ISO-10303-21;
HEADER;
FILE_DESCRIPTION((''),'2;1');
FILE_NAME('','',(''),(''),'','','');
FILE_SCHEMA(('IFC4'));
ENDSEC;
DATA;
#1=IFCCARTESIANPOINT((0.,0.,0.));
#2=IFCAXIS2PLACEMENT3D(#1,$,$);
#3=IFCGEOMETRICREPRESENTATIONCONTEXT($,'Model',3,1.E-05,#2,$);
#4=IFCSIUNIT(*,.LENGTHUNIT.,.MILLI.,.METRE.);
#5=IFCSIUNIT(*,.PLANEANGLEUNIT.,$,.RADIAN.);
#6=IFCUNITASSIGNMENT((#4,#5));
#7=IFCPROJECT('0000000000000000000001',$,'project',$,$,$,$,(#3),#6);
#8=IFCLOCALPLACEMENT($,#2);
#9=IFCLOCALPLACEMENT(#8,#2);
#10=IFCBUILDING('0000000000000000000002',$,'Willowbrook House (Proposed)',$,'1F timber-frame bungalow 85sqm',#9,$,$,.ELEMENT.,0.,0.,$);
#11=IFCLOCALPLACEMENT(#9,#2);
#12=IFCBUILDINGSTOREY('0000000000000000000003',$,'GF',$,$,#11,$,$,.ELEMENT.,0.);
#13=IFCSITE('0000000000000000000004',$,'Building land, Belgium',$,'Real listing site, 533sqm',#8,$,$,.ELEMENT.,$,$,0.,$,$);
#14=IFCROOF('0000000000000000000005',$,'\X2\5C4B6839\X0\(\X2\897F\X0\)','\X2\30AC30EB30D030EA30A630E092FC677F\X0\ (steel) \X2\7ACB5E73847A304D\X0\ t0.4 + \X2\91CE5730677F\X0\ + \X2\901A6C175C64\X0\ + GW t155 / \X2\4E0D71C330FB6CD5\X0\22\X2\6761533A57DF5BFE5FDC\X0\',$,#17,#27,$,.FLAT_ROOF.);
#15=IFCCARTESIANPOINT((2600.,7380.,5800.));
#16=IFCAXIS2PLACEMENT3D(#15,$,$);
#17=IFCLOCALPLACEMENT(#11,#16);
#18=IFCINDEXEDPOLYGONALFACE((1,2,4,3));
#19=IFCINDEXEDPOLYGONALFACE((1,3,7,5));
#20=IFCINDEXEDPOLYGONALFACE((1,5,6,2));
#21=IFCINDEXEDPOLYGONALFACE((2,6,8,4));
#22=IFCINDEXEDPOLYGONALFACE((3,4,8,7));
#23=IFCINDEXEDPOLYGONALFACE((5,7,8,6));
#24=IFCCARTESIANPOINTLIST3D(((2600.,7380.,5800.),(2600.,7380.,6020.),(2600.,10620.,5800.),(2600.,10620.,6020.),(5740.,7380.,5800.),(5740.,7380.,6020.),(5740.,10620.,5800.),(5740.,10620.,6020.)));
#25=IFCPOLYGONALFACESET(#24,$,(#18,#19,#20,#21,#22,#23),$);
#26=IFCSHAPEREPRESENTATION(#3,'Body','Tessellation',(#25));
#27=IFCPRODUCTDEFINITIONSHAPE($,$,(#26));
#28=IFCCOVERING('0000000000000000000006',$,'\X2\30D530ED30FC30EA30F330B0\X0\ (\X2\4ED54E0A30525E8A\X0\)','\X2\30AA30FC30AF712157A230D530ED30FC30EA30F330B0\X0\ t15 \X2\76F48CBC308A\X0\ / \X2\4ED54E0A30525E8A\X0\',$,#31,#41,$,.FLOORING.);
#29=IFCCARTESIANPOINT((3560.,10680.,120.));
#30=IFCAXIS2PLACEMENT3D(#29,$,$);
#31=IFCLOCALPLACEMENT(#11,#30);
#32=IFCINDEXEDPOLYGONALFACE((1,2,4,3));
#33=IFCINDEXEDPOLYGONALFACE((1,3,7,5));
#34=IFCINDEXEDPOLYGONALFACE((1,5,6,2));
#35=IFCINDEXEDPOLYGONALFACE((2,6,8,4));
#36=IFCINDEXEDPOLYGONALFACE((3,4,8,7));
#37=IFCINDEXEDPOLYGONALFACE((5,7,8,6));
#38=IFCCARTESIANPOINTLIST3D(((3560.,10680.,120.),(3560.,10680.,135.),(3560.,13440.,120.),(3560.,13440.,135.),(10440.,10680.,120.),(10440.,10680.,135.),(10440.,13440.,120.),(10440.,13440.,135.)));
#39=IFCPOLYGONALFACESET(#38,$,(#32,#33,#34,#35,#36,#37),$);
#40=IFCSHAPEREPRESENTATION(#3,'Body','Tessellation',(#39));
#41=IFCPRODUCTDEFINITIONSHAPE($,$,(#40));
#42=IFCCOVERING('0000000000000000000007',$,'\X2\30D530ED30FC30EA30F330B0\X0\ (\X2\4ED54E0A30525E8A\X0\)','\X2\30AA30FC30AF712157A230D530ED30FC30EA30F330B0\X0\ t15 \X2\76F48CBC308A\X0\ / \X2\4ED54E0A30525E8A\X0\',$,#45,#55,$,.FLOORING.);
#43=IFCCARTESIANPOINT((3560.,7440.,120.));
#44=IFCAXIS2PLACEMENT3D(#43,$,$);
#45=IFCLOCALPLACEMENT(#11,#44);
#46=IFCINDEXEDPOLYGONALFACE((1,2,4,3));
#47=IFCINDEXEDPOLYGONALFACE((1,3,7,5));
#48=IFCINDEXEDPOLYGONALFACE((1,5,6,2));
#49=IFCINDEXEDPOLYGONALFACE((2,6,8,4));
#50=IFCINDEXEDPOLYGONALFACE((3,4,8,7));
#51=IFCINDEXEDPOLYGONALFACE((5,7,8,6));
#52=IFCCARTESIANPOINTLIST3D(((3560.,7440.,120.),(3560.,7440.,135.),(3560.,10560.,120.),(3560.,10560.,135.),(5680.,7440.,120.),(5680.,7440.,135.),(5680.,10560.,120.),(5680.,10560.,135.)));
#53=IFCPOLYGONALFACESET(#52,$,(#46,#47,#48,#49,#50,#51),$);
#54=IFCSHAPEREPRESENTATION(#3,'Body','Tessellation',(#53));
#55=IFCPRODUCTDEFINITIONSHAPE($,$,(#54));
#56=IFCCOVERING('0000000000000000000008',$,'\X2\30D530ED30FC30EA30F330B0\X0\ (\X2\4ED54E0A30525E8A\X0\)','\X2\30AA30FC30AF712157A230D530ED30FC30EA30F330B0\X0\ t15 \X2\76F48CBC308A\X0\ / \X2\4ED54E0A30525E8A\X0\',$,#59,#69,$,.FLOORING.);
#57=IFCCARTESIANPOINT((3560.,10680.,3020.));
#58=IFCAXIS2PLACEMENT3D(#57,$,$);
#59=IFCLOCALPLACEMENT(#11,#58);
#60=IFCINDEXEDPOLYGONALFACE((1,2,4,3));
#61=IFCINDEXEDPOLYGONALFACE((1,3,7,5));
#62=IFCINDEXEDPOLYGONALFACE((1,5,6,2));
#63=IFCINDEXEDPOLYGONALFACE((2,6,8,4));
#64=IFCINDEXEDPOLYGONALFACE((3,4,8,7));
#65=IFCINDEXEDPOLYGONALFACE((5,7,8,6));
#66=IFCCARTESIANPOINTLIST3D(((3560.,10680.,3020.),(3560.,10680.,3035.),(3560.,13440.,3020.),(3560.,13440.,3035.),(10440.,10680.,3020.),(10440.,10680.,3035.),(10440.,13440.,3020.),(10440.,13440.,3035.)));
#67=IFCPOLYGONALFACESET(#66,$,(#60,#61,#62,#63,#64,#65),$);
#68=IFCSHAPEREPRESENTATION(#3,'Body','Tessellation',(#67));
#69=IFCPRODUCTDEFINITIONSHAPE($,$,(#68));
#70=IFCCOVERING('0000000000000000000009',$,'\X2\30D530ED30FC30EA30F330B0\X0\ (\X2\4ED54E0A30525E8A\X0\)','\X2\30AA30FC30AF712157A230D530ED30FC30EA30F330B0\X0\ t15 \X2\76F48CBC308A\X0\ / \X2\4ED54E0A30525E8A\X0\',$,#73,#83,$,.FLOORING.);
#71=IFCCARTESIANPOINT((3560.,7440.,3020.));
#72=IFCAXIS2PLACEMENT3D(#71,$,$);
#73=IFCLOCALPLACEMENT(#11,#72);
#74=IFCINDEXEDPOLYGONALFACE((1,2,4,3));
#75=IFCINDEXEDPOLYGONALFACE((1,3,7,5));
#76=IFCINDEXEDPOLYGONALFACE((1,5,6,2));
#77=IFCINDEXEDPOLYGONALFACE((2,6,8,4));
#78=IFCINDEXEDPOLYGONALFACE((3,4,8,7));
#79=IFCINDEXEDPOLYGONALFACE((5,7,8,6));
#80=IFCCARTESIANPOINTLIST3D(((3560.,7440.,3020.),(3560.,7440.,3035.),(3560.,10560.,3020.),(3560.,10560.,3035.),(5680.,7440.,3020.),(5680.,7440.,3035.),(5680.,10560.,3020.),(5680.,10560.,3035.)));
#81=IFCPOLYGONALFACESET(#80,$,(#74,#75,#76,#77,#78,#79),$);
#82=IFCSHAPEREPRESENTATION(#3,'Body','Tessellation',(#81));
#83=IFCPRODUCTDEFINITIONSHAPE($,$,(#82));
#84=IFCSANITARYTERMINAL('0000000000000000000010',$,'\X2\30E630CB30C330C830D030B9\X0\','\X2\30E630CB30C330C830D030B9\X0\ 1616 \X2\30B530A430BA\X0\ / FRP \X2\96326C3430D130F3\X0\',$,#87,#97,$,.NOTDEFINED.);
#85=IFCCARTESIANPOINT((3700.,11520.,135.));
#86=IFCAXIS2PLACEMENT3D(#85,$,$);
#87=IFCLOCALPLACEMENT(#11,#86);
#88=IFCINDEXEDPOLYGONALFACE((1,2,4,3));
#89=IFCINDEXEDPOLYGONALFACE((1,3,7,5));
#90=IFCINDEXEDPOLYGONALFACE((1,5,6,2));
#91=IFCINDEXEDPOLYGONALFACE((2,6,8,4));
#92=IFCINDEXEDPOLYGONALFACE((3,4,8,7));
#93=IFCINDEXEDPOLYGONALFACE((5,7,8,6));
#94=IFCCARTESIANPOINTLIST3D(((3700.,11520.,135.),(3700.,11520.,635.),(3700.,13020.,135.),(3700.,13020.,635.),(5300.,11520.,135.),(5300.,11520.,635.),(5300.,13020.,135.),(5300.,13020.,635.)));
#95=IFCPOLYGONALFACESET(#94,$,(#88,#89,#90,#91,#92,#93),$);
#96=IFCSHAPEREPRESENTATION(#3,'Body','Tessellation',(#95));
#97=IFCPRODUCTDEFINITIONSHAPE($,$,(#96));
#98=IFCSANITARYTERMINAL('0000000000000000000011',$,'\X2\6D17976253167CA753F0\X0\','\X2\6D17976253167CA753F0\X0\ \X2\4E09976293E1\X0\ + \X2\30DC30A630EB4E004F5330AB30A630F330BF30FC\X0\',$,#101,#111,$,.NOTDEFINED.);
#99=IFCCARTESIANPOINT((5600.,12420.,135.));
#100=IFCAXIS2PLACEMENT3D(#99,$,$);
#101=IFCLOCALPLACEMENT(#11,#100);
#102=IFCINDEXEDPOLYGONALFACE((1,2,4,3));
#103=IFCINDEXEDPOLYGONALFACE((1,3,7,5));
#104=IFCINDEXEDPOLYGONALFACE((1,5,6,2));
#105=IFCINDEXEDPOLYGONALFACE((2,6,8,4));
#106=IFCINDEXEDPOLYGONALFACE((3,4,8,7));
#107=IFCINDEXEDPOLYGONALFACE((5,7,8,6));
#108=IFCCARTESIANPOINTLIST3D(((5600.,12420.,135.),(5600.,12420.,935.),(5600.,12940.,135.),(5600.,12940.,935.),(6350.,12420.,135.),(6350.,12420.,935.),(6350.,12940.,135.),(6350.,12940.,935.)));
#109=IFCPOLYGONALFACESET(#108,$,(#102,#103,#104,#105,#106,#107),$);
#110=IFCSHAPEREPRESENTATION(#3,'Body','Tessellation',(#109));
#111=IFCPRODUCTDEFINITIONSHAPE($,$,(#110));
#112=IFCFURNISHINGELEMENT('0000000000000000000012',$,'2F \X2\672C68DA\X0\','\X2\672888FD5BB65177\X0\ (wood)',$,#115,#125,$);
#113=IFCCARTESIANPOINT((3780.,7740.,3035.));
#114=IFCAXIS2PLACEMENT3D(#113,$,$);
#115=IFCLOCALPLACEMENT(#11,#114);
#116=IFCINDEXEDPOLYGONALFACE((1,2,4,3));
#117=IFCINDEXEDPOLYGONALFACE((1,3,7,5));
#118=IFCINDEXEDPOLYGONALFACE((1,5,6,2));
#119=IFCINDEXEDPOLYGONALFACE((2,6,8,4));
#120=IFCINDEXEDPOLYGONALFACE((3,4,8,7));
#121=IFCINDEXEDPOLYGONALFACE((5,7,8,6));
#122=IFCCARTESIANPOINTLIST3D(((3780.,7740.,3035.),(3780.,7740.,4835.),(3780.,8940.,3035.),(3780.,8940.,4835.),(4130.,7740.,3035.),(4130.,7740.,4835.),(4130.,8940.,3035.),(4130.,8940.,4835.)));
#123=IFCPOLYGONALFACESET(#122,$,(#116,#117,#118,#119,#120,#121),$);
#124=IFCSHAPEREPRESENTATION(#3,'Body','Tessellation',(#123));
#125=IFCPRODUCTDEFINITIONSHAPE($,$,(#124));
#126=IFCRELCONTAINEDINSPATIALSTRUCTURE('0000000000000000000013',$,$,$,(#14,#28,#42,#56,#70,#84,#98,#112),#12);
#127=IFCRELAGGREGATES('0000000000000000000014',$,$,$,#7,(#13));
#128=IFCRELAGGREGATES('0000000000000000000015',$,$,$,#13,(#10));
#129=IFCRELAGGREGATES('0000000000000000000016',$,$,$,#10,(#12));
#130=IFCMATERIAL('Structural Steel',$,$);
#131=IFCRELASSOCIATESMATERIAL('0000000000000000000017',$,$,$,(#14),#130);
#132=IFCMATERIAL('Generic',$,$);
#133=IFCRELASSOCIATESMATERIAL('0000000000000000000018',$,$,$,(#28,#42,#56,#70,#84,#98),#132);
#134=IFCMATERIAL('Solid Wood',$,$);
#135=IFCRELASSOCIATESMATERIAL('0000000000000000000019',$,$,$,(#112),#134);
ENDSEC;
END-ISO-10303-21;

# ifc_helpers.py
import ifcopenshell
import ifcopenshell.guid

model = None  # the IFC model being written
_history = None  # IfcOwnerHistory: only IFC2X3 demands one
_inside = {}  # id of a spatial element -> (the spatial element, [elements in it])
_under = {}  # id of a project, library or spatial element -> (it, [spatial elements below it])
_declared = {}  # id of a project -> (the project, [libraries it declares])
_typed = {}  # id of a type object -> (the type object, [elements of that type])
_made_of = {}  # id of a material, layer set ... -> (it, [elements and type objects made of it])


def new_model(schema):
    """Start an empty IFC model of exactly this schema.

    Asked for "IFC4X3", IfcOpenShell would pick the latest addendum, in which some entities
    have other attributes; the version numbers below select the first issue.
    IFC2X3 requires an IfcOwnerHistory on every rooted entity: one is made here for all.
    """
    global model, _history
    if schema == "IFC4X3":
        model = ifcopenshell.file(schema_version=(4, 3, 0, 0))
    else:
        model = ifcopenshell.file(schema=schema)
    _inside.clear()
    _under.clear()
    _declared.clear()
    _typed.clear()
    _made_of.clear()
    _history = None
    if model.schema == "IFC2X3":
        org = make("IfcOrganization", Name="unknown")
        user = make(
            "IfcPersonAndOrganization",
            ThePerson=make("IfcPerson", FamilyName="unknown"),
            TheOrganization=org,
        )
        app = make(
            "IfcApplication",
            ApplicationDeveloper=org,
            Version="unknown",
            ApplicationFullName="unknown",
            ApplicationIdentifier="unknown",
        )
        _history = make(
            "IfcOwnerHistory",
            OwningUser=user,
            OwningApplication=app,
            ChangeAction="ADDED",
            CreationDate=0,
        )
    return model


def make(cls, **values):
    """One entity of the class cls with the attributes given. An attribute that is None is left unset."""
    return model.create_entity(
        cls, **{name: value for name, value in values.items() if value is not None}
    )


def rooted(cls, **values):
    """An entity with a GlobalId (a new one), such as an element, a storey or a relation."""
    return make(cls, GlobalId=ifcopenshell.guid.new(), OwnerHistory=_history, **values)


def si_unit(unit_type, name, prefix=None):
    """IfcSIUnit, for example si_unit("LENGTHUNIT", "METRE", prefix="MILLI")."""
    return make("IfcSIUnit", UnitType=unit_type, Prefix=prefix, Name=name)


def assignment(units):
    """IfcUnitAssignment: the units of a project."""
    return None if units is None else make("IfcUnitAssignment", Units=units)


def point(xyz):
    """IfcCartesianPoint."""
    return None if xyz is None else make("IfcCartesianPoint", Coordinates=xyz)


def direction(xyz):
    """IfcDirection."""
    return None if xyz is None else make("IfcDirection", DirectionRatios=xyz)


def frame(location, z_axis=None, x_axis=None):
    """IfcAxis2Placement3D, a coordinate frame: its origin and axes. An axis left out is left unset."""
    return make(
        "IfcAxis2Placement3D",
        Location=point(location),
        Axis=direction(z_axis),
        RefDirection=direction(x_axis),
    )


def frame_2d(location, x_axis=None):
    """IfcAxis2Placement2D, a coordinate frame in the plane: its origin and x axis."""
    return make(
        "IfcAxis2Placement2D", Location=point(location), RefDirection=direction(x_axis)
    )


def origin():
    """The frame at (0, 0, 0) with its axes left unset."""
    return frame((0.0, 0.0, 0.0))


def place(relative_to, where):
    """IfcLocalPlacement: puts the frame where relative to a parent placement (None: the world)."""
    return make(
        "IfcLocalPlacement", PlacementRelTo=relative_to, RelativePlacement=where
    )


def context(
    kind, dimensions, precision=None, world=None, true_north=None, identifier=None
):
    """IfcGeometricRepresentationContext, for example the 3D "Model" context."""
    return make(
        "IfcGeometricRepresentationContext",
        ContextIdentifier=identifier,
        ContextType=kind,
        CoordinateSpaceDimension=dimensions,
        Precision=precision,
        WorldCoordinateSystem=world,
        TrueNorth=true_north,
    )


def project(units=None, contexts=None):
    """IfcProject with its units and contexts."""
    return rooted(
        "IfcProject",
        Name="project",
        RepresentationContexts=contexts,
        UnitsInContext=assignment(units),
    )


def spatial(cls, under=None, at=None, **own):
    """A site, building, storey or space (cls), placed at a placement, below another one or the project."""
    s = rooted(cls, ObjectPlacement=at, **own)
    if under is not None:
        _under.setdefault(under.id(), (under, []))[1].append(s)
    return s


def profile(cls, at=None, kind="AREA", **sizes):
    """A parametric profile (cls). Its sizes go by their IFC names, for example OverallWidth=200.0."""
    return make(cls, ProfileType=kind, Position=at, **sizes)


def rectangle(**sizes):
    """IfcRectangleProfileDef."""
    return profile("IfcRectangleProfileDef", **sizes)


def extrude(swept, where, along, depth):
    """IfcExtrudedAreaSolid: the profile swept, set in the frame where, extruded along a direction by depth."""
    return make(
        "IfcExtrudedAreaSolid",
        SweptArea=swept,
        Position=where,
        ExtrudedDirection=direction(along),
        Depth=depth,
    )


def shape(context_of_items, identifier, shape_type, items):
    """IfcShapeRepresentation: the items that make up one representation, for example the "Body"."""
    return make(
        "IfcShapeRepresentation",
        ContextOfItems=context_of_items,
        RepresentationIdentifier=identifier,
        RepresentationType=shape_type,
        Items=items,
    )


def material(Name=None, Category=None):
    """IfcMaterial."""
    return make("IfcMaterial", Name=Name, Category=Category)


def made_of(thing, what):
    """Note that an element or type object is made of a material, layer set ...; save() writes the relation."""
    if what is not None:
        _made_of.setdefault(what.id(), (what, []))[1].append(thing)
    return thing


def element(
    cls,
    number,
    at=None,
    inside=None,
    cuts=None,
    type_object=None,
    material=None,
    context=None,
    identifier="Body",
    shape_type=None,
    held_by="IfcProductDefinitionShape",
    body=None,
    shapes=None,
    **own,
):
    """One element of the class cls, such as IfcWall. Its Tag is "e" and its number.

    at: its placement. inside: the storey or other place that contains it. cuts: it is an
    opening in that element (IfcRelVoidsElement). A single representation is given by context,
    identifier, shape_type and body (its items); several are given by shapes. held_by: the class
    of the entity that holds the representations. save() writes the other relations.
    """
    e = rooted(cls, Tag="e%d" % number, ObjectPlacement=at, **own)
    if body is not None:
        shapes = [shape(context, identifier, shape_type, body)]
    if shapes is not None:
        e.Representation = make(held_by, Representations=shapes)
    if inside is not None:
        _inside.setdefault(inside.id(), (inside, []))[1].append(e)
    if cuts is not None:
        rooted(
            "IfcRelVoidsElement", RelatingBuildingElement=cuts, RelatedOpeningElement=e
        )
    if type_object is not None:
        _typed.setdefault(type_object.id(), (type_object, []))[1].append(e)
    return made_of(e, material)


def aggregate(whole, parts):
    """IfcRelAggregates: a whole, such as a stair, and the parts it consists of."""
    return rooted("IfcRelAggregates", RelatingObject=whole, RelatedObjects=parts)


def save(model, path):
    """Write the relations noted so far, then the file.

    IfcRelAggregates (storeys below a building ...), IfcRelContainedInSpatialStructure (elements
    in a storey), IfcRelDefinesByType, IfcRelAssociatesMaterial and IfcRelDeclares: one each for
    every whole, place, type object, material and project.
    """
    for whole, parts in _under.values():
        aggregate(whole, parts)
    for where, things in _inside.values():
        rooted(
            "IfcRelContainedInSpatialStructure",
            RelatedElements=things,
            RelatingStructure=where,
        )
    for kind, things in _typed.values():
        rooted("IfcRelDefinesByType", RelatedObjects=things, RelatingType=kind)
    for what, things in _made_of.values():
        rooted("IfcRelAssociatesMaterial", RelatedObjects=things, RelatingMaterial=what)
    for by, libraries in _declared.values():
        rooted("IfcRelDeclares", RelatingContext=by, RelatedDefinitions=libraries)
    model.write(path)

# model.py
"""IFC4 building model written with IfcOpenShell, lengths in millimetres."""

from ifc_helpers import new_model, si_unit, frame, frame_2d, origin, place, context, project, spatial, rectangle, extrude, material, element, save


model = new_model("IFC4")

# Units and contexts
model_context = context("Model", 3, precision=1e-05, world=origin())
ifc_project = project(units=[si_unit("LENGTHUNIT", "METRE", prefix="MILLI"), si_unit("PLANEANGLEUNIT", "RADIAN")], contexts=[model_context])

# Site, building, storey
site_placement = place(None, origin())
site = spatial("IfcSite", under=ifc_project, at=site_placement, Name="Building land, Belgium", ObjectType="Real listing site, 533sqm", CompositionType="ELEMENT", RefElevation=0.0)
building_placement = place(site_placement, origin())
building = spatial("IfcBuilding", under=site, at=building_placement, Name="Willowbrook House (Proposed)", ObjectType="1F timber-frame bungalow 85sqm", CompositionType="ELEMENT", ElevationOfRefHeight=0.0, ElevationOfTerrain=0.0)
storey_placement = place(building_placement, origin())
storey = spatial("IfcBuildingStorey", under=building, at=storey_placement, Name="GF", CompositionType="ELEMENT", Elevation=0.0)

# Shared definitions
ifc_material_1 = material(Name="Solid Wood")

# Roof
ifc_material_2 = material(Name="Structural Steel")
roof_placement = place(storey_placement, frame((2600.0, 7380.0, 5800.0)))
element("IfcRoof", 1, at=roof_placement, inside=storey, material=ifc_material_2, Name="屋根(西)", Description="ガルバリウム鋼板 (steel) 立平葺き t0.4 + 野地板 + 通気層 + GW t155 / 不燃・法22条区域対応", PredefinedType="FLAT_ROOF", context=model_context, shape_type="SweptSolid", body=[
    extrude(rectangle(XDim=3140.0, YDim=3240.0, at=frame_2d((1570.0, 1620.0))), frame((2600.0, 7380.0, 5800.0)), (0.0, 0.0, 1.0), 220.0),
])

# Coverings
ifc_material_3 = material(Name="Generic")
covering_1_placement = place(storey_placement, frame((3560.0, 10680.0, 120.0)))
element("IfcCovering", 2, at=covering_1_placement, inside=storey, material=ifc_material_3, Name="フローリング (仕上げ床)", Description="オーク無垢フローリング t15 直貼り / 仕上げ床", PredefinedType="FLOORING", context=model_context, shape_type="SweptSolid", body=[
    extrude(rectangle(XDim=6880.0, YDim=2760.0, at=frame_2d((3440.0, 1380.0))), frame((3560.0, 10680.0, 120.0)), (0.0, 0.0, 1.0), 15.0),
])
covering_2_placement = place(storey_placement, frame((3560.0, 7440.0, 120.0)))
element("IfcCovering", 3, at=covering_2_placement, inside=storey, material=ifc_material_3, Name="フローリング (仕上げ床)", Description="オーク無垢フローリング t15 直貼り / 仕上げ床", PredefinedType="FLOORING", context=model_context, shape_type="SweptSolid", body=[
    extrude(rectangle(XDim=2120.0, YDim=3120.0, at=frame_2d((1060.0, 1560.0))), frame((3560.0, 7440.0, 120.0)), (0.0, 0.0, 1.0), 15.0),
])
covering_3_placement = place(storey_placement, frame((3560.0, 10680.0, 3020.0)))
element("IfcCovering", 4, at=covering_3_placement, inside=storey, material=ifc_material_3, Name="フローリング (仕上げ床)", Description="オーク無垢フローリング t15 直貼り / 仕上げ床", PredefinedType="FLOORING", context=model_context, shape_type="SweptSolid", body=[
    extrude(rectangle(XDim=6880.0, YDim=2760.0, at=frame_2d((3440.0, 1380.0))), frame((3560.0, 10680.0, 3020.0)), (0.0, 0.0, 1.0), 15.0),
])
covering_4_placement = place(storey_placement, frame((3560.0, 7440.0, 3020.0)))
element("IfcCovering", 5, at=covering_4_placement, inside=storey, material=ifc_material_3, Name="フローリング (仕上げ床)", Description="オーク無垢フローリング t15 直貼り / 仕上げ床", PredefinedType="FLOORING", context=model_context, shape_type="SweptSolid", body=[
    extrude(rectangle(XDim=2120.0, YDim=3120.0, at=frame_2d((1060.0, 1560.0))), frame((3560.0, 7440.0, 3020.0)), (0.0, 0.0, 1.0), 15.0),
])

# Sanitary terminals
sanitary_terminal_1_placement = place(storey_placement, frame((3700.0, 11520.0, 135.0)))
element("IfcSanitaryTerminal", 6, at=sanitary_terminal_1_placement, inside=storey, material=ifc_material_3, Name="ユニットバス", Description="ユニットバス 1616 サイズ / FRP 防水パン", PredefinedType="NOTDEFINED", context=model_context, shape_type="SweptSolid", body=[
    extrude(rectangle(XDim=1600.0, YDim=1500.0, at=frame_2d((800.0, 750.0))), frame((3700.0, 11520.0, 135.0)), (0.0, 0.0, 1.0), 500.0),
])
sanitary_terminal_2_placement = place(storey_placement, frame((5600.0, 12420.0, 135.0)))
element("IfcSanitaryTerminal", 7, at=sanitary_terminal_2_placement, inside=storey, material=ifc_material_3, Name="洗面化粧台", Description="洗面化粧台 三面鏡 + ボウル一体カウンター", PredefinedType="NOTDEFINED", context=model_context, shape_type="SweptSolid", body=[
    extrude(rectangle(XDim=750.0, YDim=520.0, at=frame_2d((375.0, 260.0))), frame((5600.0, 12420.0, 135.0)), (0.0, 0.0, 1.0), 800.0),
])

# Furnishing element
furnishing_placement = place(storey_placement, frame((3780.0, 7740.0, 3035.0)))
element("IfcFurnishingElement", 8, at=furnishing_placement, inside=storey, material=ifc_material_1, Name="2F 本棚", Description="木製家具 (wood)", context=model_context, shape_type="SweptSolid", body=[
    extrude(rectangle(XDim=350.0, YDim=1200.0, at=frame_2d((175.0, 600.0))), frame((3780.0, 7740.0, 3035.0)), (0.0, 0.0, 1.0), 1800.0),
])

save(model, "model.ifc")
